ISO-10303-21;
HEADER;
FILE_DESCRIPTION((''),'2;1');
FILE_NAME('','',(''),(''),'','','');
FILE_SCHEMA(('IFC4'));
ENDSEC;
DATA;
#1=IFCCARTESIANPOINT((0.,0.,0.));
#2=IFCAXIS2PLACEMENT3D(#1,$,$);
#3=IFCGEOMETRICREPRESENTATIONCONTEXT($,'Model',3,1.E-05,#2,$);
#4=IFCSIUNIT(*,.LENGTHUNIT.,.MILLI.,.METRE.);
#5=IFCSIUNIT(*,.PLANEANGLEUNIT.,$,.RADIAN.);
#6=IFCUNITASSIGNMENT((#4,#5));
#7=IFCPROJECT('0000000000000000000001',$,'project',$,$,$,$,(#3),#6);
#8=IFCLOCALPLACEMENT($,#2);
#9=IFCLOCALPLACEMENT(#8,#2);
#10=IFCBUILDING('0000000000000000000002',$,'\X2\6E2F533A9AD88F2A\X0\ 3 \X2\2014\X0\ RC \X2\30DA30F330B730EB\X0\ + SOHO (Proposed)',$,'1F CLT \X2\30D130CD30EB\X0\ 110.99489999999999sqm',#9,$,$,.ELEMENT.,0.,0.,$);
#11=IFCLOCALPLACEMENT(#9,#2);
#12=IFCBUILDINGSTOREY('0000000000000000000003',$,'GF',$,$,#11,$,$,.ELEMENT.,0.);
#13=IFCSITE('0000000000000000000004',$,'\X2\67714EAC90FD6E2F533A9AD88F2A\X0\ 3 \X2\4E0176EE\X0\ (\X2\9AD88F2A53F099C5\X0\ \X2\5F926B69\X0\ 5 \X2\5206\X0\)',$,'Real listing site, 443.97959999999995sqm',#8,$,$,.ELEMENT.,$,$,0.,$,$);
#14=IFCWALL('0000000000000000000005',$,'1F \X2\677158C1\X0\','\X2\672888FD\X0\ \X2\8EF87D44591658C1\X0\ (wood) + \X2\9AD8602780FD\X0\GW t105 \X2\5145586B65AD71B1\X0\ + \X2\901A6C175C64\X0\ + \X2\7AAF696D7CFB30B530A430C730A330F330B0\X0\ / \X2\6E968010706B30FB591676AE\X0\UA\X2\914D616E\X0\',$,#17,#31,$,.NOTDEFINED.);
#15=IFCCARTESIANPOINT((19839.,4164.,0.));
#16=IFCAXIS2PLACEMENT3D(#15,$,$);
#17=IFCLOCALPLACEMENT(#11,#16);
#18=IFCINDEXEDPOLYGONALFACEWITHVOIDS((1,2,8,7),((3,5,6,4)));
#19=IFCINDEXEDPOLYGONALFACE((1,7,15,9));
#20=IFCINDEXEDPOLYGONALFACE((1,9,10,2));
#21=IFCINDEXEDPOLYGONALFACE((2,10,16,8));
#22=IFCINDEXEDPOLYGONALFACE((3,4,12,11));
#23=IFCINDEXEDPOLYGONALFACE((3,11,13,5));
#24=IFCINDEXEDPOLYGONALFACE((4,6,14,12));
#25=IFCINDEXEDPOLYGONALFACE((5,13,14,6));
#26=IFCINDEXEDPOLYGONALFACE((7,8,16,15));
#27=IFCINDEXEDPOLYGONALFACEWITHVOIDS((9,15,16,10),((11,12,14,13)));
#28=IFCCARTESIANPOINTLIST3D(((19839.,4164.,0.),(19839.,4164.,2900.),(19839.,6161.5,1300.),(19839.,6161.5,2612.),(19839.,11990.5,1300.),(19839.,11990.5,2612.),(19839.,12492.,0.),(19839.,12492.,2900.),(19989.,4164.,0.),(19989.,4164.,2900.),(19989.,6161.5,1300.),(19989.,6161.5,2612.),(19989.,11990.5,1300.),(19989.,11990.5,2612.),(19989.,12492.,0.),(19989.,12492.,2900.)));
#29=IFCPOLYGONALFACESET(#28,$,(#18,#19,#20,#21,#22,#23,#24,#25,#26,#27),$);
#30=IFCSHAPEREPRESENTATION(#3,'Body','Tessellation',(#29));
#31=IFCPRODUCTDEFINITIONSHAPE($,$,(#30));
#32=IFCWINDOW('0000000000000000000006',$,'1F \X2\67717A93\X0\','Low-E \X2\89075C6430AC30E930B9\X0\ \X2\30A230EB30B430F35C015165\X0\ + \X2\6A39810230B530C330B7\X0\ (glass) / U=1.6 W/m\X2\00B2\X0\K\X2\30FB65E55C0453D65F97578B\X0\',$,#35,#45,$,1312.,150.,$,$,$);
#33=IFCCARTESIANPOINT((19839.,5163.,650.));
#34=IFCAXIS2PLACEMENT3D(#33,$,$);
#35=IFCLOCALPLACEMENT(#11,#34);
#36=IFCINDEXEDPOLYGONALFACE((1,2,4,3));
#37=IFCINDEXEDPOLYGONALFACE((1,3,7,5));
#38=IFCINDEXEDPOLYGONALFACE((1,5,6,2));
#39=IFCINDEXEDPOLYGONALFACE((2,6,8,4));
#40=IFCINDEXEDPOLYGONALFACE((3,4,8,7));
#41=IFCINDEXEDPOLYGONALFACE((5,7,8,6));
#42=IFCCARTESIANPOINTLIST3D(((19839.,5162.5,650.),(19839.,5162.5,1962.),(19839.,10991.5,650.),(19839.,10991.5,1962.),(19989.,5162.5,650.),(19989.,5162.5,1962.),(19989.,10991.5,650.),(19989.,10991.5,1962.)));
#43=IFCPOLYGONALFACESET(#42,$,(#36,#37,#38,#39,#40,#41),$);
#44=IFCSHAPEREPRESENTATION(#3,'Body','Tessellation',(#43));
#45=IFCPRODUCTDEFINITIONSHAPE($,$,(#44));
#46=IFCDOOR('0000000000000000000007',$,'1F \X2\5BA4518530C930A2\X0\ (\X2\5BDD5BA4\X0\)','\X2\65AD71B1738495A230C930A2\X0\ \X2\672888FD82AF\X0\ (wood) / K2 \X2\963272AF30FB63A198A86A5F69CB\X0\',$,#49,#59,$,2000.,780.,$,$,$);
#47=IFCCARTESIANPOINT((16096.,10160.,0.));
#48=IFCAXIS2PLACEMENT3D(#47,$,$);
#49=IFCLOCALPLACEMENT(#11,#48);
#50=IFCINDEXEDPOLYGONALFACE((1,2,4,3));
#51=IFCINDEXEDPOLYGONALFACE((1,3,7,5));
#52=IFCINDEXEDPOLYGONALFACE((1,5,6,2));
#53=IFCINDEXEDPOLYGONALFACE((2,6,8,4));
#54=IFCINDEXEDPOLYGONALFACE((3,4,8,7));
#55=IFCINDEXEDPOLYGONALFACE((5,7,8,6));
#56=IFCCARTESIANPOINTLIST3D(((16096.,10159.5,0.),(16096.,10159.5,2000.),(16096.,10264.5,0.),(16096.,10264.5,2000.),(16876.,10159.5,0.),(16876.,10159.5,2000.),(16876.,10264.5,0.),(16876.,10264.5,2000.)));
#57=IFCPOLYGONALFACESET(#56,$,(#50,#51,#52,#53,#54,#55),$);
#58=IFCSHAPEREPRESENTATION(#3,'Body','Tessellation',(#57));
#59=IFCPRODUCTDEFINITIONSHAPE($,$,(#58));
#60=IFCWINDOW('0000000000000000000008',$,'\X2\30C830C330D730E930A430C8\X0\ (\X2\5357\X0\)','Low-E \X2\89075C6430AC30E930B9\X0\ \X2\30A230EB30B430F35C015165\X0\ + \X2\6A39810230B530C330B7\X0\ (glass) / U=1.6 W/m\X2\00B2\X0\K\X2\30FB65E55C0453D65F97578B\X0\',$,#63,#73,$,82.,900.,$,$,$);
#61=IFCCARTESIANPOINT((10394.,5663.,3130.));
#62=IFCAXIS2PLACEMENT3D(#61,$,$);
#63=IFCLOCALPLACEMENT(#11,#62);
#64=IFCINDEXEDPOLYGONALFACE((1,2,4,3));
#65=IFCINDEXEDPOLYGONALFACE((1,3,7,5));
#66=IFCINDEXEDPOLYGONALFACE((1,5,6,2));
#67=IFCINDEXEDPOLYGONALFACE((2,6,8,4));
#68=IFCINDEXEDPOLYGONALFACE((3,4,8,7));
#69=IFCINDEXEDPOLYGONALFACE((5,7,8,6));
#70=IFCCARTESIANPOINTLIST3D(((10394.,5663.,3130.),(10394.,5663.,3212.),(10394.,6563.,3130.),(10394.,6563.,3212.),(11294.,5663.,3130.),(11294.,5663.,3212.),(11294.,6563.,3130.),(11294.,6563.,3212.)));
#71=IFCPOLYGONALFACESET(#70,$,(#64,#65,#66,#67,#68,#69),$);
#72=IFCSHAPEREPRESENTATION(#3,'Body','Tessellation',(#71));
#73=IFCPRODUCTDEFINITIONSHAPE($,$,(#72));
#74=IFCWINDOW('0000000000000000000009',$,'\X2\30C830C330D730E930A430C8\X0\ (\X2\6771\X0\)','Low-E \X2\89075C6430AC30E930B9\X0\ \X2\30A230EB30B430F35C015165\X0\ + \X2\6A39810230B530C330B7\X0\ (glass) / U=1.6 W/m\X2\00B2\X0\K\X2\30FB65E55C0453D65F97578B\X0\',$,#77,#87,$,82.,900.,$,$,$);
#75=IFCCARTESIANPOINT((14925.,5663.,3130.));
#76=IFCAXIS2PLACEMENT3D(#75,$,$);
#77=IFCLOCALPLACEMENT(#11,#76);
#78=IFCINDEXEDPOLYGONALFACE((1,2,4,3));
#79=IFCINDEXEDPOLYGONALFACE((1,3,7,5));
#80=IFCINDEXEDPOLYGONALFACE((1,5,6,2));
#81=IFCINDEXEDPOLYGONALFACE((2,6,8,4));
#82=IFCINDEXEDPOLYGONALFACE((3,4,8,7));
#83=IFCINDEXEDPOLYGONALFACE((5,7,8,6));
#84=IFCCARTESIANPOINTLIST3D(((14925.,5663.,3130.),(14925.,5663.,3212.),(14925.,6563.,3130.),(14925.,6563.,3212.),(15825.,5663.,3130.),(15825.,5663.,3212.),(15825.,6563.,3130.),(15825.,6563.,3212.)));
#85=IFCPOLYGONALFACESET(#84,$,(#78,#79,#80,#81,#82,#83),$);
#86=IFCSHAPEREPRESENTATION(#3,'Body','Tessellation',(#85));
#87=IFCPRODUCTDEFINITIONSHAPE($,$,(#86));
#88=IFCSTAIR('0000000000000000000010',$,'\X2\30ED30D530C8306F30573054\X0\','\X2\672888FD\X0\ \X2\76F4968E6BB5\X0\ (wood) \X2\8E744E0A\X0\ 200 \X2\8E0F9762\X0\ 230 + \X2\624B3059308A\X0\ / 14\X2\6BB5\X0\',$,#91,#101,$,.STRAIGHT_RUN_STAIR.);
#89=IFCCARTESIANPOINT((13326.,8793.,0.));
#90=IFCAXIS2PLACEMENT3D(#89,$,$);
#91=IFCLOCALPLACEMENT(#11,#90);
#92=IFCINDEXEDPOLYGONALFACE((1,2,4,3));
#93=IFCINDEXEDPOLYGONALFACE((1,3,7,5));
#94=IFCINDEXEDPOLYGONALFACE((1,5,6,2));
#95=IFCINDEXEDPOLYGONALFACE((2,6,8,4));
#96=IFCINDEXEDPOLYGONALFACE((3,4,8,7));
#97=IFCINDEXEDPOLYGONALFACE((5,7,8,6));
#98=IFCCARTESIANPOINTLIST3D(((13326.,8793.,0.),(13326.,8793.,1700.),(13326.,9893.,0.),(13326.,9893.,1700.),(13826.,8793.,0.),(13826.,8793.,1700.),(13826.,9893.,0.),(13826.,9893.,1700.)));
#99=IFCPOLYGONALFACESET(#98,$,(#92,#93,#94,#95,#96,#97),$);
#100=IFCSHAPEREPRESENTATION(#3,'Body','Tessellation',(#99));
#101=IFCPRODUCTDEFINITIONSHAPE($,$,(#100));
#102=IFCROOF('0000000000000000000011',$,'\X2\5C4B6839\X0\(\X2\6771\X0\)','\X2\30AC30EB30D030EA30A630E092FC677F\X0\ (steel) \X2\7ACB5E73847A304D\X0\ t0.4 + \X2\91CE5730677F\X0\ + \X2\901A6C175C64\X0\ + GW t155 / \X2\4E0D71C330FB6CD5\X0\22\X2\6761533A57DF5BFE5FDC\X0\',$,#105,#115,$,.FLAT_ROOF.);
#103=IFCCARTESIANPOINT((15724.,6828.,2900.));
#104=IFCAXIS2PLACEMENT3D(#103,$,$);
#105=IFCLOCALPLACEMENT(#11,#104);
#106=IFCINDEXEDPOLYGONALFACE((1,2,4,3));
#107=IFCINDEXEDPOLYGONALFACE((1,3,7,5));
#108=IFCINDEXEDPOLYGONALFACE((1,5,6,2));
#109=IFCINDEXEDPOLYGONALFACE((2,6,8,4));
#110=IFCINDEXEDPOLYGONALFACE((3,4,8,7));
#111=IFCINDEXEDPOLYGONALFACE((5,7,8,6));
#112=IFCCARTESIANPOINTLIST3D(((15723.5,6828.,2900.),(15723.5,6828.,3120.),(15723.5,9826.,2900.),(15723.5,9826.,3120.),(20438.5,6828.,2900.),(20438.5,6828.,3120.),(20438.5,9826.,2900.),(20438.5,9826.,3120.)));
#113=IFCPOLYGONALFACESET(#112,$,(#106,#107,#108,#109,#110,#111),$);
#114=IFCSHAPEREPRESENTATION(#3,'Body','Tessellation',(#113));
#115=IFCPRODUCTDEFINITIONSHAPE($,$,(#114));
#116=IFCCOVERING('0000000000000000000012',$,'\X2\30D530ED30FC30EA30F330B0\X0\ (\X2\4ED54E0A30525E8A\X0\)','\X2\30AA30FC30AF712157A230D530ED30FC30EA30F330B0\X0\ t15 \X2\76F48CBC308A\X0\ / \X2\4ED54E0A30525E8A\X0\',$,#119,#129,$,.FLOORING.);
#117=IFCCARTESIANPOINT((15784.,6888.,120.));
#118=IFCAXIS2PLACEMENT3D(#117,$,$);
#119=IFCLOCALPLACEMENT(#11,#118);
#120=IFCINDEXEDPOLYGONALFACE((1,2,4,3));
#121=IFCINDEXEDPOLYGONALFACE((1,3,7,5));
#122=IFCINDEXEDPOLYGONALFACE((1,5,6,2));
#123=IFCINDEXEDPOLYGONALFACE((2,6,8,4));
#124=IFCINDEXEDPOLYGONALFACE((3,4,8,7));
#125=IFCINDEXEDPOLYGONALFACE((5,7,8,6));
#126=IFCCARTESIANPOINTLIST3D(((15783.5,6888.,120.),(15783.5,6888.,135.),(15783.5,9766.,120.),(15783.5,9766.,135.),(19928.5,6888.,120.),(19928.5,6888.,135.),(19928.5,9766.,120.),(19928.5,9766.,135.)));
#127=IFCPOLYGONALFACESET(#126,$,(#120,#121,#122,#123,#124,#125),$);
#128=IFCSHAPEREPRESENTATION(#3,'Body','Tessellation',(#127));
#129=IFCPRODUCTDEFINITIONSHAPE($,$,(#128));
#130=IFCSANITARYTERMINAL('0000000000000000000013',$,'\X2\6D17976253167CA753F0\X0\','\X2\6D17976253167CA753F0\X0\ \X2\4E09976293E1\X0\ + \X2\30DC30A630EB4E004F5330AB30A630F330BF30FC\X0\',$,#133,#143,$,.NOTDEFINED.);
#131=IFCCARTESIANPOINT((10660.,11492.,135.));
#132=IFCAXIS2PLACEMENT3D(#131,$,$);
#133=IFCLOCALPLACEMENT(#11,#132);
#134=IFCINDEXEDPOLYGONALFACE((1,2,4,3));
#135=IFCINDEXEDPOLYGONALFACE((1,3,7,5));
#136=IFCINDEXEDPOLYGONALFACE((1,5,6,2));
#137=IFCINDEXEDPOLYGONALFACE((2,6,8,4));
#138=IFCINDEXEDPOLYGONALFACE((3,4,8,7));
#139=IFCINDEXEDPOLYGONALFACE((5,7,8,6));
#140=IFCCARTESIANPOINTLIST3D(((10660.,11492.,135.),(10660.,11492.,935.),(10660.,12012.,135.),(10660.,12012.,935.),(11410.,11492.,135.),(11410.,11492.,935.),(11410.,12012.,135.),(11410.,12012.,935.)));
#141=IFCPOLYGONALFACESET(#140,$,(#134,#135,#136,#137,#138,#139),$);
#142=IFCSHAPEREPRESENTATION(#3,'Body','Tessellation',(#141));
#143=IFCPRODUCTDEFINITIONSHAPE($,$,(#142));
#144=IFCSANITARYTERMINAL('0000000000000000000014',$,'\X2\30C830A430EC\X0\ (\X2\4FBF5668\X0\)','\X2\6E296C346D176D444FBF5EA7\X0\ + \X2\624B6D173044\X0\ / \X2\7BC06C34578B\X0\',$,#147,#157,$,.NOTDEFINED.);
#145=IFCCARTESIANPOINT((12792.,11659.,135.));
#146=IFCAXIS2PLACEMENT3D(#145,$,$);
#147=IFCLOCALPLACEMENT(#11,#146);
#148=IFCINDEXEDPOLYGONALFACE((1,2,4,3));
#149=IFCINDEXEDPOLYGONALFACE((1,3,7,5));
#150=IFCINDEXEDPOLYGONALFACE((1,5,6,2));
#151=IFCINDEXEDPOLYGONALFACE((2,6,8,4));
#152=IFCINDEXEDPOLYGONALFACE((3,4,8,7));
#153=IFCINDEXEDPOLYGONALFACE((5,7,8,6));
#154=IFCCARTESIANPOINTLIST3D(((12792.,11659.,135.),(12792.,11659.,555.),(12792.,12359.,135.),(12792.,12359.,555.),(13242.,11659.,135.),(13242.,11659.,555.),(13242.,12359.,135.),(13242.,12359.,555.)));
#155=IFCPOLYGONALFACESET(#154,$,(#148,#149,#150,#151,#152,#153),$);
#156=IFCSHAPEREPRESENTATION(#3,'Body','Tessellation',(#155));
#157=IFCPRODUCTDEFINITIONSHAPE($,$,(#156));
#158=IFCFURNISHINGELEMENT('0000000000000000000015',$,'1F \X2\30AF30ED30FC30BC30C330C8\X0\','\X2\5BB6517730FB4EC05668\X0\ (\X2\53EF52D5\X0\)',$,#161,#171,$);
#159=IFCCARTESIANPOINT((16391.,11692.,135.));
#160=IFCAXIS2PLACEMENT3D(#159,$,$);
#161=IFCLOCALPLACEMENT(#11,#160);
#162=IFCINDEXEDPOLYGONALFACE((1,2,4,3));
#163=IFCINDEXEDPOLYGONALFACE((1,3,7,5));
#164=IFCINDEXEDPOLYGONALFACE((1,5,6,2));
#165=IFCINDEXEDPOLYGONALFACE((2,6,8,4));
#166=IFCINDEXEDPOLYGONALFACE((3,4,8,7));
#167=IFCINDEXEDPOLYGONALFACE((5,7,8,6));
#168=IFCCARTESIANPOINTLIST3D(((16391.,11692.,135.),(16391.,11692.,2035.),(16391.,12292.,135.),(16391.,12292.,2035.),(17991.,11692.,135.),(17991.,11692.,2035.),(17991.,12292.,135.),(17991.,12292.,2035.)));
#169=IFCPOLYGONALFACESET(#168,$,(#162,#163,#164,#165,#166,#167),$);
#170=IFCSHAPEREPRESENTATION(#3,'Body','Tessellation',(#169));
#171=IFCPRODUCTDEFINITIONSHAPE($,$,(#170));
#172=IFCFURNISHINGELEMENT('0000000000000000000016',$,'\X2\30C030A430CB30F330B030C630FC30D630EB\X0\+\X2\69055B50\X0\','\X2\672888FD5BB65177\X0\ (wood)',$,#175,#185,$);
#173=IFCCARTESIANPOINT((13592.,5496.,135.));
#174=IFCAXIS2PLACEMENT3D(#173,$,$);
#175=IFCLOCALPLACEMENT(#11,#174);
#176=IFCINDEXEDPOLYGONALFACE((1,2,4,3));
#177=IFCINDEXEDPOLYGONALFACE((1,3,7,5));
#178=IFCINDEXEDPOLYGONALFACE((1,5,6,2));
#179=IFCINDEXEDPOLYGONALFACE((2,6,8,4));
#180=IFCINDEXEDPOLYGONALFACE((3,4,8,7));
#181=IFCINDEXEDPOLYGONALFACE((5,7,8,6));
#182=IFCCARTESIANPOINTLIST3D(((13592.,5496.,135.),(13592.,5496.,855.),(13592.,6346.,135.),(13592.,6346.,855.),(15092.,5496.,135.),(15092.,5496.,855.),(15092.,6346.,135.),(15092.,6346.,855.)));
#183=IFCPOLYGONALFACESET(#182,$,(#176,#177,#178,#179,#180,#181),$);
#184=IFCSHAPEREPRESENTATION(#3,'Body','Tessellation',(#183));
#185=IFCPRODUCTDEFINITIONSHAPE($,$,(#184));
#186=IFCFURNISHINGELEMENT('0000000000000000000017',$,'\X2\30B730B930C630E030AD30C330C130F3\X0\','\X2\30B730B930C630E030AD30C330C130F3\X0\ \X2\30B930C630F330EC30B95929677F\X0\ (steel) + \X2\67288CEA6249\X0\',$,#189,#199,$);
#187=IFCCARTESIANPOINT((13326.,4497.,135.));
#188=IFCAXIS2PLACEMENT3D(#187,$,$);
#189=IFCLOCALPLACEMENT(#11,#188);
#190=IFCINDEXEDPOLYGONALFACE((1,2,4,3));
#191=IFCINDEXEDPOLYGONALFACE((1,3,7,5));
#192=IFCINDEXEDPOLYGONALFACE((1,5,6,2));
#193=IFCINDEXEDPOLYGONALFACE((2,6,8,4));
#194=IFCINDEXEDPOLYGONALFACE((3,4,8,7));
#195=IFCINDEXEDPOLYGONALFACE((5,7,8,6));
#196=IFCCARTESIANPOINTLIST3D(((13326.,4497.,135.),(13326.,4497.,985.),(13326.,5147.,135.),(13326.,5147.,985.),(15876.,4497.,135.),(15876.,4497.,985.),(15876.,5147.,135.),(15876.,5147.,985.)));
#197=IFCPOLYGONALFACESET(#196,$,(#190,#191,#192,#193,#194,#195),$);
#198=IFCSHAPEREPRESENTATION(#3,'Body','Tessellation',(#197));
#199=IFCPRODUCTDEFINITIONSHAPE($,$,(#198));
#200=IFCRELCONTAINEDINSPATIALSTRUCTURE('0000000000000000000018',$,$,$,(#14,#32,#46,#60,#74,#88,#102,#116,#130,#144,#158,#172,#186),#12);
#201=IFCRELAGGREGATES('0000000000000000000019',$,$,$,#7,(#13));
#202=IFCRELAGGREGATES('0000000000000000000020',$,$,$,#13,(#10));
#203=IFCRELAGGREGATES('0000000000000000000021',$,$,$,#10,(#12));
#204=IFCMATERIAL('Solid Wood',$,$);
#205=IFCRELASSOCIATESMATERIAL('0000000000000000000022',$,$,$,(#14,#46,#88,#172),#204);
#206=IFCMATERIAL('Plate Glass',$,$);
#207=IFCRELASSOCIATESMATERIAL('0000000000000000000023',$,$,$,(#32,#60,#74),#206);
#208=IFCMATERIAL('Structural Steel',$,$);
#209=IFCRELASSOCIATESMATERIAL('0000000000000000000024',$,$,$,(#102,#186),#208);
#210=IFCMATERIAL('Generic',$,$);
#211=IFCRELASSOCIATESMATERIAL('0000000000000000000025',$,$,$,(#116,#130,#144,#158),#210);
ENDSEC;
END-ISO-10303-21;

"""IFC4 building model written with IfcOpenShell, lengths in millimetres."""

from ifc_helpers import new_model, si_unit, frame, frame_2d, origin, place, context, project, spatial, rectangle, extrude, material, element, fill, save


model = new_model("IFC4")

# Units and contexts
model_context = context("Model", 3, precision=1e-05, world=origin())
ifc_project = project(units=[si_unit("LENGTHUNIT", "METRE", prefix="MILLI"), si_unit("PLANEANGLEUNIT", "RADIAN")], contexts=[model_context])

# Site, building, storey
site_placement = place(None, origin())
site = spatial("IfcSite", under=ifc_project, at=site_placement, Name="東京都港区高輪 3 丁目 (高輪台駅 徒歩 5 分)", ObjectType="Real listing site, 443.97959999999995sqm", CompositionType="ELEMENT", RefElevation=0.0)
building_placement = place(site_placement, origin())
building = spatial("IfcBuilding", under=site, at=building_placement, Name="港区高輪 3 — RC ペンシル + SOHO (Proposed)", ObjectType="1F CLT パネル 110.99489999999999sqm", CompositionType="ELEMENT", ElevationOfRefHeight=0.0, ElevationOfTerrain=0.0)
storey_placement = place(building_placement, origin())
storey = spatial("IfcBuildingStorey", under=building, at=storey_placement, Name="GF", CompositionType="ELEMENT", Elevation=0.0)

# Shared definitions
ifc_material_1 = material(Name="Solid Wood")

# Wall, opening, window
wall_1_placement = place(storey_placement, frame((19839.0, 4164.0, 0.0)))
wall_1 = element("IfcWall", 1, at=wall_1_placement, inside=storey, material=ifc_material_1, Name="1F 東壁", Description="木製 軸組外壁 (wood) + 高性能GW t105 充填断熱 + 通気層 + 窯業系サイディング / 準耐火・外皮UA配慮", PredefinedType="NOTDEFINED", context=model_context, shape_type="SweptSolid", body=[
    extrude(rectangle(XDim=150.0, YDim=8328.0, at=frame_2d((75.0, 4164.0))), frame((19839.0, 4164.0, 0.0)), (0.0, 0.0, 1.0), 2900.0),
])
opening_1_placement = place(storey_placement, frame((19839.0, 5163.0, 650.0)))
opening_1 = element("IfcOpeningElement", 2, at=opening_1_placement, cuts=wall_1, PredefinedType="NOTDEFINED", context=model_context, shape_type="SweptSolid", body=[
    extrude(rectangle(XDim=150.0, YDim=5829.0, at=frame_2d((75.0, 2914.0))), frame((19839.0, 5163.0, 650.0)), (0.0, 0.0, 1.0), 1312.0),
])
ifc_material_2 = material(Name="Plate Glass")
window_1_placement = place(storey_placement, frame((19839.0, 5163.0, 650.0)))
window_1 = element("IfcWindow", 3, at=window_1_placement, inside=storey, material=ifc_material_2, Name="1F 東窓", Description="Low-E 複層ガラス アルゴン封入 + 樹脂サッシ (glass) / U=1.6 W/m²K・日射取得型", OverallHeight=1312.0, OverallWidth=150.0, context=model_context, shape_type="SweptSolid", body=[
    extrude(rectangle(XDim=150.0, YDim=5829.0, at=frame_2d((75.0, 2914.0))), frame((19839.0, 5163.0, 650.0)), (0.0, 0.0, 1.0), 1312.0),
])
fill(opening_1, window_1)

# Door
door_placement = place(storey_placement, frame((16096.0, 10160.0, 0.0)))
element("IfcDoor", 4, at=door_placement, inside=storey, material=ifc_material_1, Name="1F 室内ドア (寝室)", Description="断熱玄関ドア 木製芯 (wood) / K2 防犯・採風機構", OverallHeight=2000.0, OverallWidth=780.0, context=model_context, shape_type="SweptSolid", body=[
    extrude(rectangle(XDim=780.0, YDim=105.0, at=frame_2d((390.0, 52.0))), frame((16096.0, 10160.0, 0.0)), (0.0, 0.0, 1.0), 2000.0),
])

# Windows
window_2_placement = place(storey_placement, frame((10394.0, 5663.0, 3130.0)))
element("IfcWindow", 5, at=window_2_placement, inside=storey, material=ifc_material_2, Name="トップライト (南)", Description="Low-E 複層ガラス アルゴン封入 + 樹脂サッシ (glass) / U=1.6 W/m²K・日射取得型", OverallHeight=82.0, OverallWidth=900.0, context=model_context, shape_type="SweptSolid", body=[
    extrude(rectangle(XDim=900.0, YDim=900.0, at=frame_2d((450.0, 450.0))), frame((10394.0, 5663.0, 3130.0)), (0.0, 0.0, 1.0), 82.0),
])
window_3_placement = place(storey_placement, frame((14925.0, 5663.0, 3130.0)))
element("IfcWindow", 6, at=window_3_placement, inside=storey, material=ifc_material_2, Name="トップライト (東)", Description="Low-E 複層ガラス アルゴン封入 + 樹脂サッシ (glass) / U=1.6 W/m²K・日射取得型", OverallHeight=82.0, OverallWidth=900.0, context=model_context, shape_type="SweptSolid", body=[
    extrude(rectangle(XDim=900.0, YDim=900.0, at=frame_2d((450.0, 450.0))), frame((14925.0, 5663.0, 3130.0)), (0.0, 0.0, 1.0), 82.0),
])

# Stair
stair_placement = place(storey_placement, frame((13326.0, 8793.0, 0.0)))
element("IfcStair", 7, at=stair_placement, inside=storey, material=ifc_material_1, Name="ロフトはしご", Description="木製 直階段 (wood) 蹴上 200 踏面 230 + 手すり / 14段", PredefinedType="STRAIGHT_RUN_STAIR", context=model_context, shape_type="SweptSolid", body=[
    extrude(rectangle(XDim=500.0, YDim=1100.0, at=frame_2d((250.0, 550.0))), frame((13326.0, 8793.0, 0.0)), (0.0, 0.0, 1.0), 1700.0),
])

# Roof
ifc_material_3 = material(Name="Structural Steel")
roof_placement = place(storey_placement, frame((15724.0, 6828.0, 2900.0)))
element("IfcRoof", 8, at=roof_placement, inside=storey, material=ifc_material_3, Name="屋根(東)", Description="ガルバリウム鋼板 (steel) 立平葺き t0.4 + 野地板 + 通気層 + GW t155 / 不燃・法22条区域対応", PredefinedType="FLAT_ROOF", context=model_context, shape_type="SweptSolid", body=[
    extrude(rectangle(XDim=4715.0, YDim=2998.0, at=frame_2d((2357.0, 1499.0))), frame((15724.0, 6828.0, 2900.0)), (0.0, 0.0, 1.0), 220.0),
])

# Covering
ifc_material_4 = material(Name="Generic")
covering_placement = place(storey_placement, frame((15784.0, 6888.0, 120.0)))
element("IfcCovering", 9, at=covering_placement, inside=storey, material=ifc_material_4, Name="フローリング (仕上げ床)", Description="オーク無垢フローリング t15 直貼り / 仕上げ床", PredefinedType="FLOORING", context=model_context, shape_type="SweptSolid", body=[
    extrude(rectangle(XDim=4145.0, YDim=2878.0, at=frame_2d((2072.0, 1439.0))), frame((15784.0, 6888.0, 120.0)), (0.0, 0.0, 1.0), 15.0),
])

# Sanitary terminals
sanitary_terminal_1_placement = place(storey_placement, frame((10660.0, 11492.0, 135.0)))
element("IfcSanitaryTerminal", 10, at=sanitary_terminal_1_placement, inside=storey, material=ifc_material_4, Name="洗面化粧台", Description="洗面化粧台 三面鏡 + ボウル一体カウンター", PredefinedType="NOTDEFINED", context=model_context, shape_type="SweptSolid", body=[
    extrude(rectangle(XDim=750.0, YDim=520.0, at=frame_2d((375.0, 260.0))), frame((10660.0, 11492.0, 135.0)), (0.0, 0.0, 1.0), 800.0),
])
sanitary_terminal_2_placement = place(storey_placement, frame((12792.0, 11659.0, 135.0)))
element("IfcSanitaryTerminal", 11, at=sanitary_terminal_2_placement, inside=storey, material=ifc_material_4, Name="トイレ (便器)", Description="温水洗浄便座 + 手洗い / 節水型", PredefinedType="NOTDEFINED", context=model_context, shape_type="SweptSolid", body=[
    extrude(rectangle(XDim=450.0, YDim=700.0, at=frame_2d((225.0, 350.0))), frame((12792.0, 11659.0, 135.0)), (0.0, 0.0, 1.0), 420.0),
])

# Furnishing elements
furnishing_1_placement = place(storey_placement, frame((16391.0, 11692.0, 135.0)))
element("IfcFurnishingElement", 12, at=furnishing_1_placement, inside=storey, material=ifc_material_4, Name="1F クローゼット", Description="家具・什器 (可動)", context=model_context, shape_type="SweptSolid", body=[
    extrude(rectangle(XDim=1600.0, YDim=600.0, at=frame_2d((800.0, 300.0))), frame((16391.0, 11692.0, 135.0)), (0.0, 0.0, 1.0), 1900.0),
])
furnishing_2_placement = place(storey_placement, frame((13592.0, 5496.0, 135.0)))
element("IfcFurnishingElement", 13, at=furnishing_2_placement, inside=storey, material=ifc_material_1, Name="ダイニングテーブル+椅子", Description="木製家具 (wood)", context=model_context, shape_type="SweptSolid", body=[
    extrude(rectangle(XDim=1500.0, YDim=850.0, at=frame_2d((750.0, 425.0))), frame((13592.0, 5496.0, 135.0)), (0.0, 0.0, 1.0), 720.0),
])
furnishing_3_placement = place(storey_placement, frame((13326.0, 4497.0, 135.0)))
element("IfcFurnishingElement", 14, at=furnishing_3_placement, inside=storey, material=ifc_material_3, Name="システムキッチン", Description="システムキッチン ステンレス天板 (steel) + 木質扉", context=model_context, shape_type="SweptSolid", body=[
    extrude(rectangle(XDim=2550.0, YDim=650.0, at=frame_2d((1275.0, 325.0))), frame((13326.0, 4497.0, 135.0)), (0.0, 0.0, 1.0), 850.0),
])

save(model, "model.ifc")
